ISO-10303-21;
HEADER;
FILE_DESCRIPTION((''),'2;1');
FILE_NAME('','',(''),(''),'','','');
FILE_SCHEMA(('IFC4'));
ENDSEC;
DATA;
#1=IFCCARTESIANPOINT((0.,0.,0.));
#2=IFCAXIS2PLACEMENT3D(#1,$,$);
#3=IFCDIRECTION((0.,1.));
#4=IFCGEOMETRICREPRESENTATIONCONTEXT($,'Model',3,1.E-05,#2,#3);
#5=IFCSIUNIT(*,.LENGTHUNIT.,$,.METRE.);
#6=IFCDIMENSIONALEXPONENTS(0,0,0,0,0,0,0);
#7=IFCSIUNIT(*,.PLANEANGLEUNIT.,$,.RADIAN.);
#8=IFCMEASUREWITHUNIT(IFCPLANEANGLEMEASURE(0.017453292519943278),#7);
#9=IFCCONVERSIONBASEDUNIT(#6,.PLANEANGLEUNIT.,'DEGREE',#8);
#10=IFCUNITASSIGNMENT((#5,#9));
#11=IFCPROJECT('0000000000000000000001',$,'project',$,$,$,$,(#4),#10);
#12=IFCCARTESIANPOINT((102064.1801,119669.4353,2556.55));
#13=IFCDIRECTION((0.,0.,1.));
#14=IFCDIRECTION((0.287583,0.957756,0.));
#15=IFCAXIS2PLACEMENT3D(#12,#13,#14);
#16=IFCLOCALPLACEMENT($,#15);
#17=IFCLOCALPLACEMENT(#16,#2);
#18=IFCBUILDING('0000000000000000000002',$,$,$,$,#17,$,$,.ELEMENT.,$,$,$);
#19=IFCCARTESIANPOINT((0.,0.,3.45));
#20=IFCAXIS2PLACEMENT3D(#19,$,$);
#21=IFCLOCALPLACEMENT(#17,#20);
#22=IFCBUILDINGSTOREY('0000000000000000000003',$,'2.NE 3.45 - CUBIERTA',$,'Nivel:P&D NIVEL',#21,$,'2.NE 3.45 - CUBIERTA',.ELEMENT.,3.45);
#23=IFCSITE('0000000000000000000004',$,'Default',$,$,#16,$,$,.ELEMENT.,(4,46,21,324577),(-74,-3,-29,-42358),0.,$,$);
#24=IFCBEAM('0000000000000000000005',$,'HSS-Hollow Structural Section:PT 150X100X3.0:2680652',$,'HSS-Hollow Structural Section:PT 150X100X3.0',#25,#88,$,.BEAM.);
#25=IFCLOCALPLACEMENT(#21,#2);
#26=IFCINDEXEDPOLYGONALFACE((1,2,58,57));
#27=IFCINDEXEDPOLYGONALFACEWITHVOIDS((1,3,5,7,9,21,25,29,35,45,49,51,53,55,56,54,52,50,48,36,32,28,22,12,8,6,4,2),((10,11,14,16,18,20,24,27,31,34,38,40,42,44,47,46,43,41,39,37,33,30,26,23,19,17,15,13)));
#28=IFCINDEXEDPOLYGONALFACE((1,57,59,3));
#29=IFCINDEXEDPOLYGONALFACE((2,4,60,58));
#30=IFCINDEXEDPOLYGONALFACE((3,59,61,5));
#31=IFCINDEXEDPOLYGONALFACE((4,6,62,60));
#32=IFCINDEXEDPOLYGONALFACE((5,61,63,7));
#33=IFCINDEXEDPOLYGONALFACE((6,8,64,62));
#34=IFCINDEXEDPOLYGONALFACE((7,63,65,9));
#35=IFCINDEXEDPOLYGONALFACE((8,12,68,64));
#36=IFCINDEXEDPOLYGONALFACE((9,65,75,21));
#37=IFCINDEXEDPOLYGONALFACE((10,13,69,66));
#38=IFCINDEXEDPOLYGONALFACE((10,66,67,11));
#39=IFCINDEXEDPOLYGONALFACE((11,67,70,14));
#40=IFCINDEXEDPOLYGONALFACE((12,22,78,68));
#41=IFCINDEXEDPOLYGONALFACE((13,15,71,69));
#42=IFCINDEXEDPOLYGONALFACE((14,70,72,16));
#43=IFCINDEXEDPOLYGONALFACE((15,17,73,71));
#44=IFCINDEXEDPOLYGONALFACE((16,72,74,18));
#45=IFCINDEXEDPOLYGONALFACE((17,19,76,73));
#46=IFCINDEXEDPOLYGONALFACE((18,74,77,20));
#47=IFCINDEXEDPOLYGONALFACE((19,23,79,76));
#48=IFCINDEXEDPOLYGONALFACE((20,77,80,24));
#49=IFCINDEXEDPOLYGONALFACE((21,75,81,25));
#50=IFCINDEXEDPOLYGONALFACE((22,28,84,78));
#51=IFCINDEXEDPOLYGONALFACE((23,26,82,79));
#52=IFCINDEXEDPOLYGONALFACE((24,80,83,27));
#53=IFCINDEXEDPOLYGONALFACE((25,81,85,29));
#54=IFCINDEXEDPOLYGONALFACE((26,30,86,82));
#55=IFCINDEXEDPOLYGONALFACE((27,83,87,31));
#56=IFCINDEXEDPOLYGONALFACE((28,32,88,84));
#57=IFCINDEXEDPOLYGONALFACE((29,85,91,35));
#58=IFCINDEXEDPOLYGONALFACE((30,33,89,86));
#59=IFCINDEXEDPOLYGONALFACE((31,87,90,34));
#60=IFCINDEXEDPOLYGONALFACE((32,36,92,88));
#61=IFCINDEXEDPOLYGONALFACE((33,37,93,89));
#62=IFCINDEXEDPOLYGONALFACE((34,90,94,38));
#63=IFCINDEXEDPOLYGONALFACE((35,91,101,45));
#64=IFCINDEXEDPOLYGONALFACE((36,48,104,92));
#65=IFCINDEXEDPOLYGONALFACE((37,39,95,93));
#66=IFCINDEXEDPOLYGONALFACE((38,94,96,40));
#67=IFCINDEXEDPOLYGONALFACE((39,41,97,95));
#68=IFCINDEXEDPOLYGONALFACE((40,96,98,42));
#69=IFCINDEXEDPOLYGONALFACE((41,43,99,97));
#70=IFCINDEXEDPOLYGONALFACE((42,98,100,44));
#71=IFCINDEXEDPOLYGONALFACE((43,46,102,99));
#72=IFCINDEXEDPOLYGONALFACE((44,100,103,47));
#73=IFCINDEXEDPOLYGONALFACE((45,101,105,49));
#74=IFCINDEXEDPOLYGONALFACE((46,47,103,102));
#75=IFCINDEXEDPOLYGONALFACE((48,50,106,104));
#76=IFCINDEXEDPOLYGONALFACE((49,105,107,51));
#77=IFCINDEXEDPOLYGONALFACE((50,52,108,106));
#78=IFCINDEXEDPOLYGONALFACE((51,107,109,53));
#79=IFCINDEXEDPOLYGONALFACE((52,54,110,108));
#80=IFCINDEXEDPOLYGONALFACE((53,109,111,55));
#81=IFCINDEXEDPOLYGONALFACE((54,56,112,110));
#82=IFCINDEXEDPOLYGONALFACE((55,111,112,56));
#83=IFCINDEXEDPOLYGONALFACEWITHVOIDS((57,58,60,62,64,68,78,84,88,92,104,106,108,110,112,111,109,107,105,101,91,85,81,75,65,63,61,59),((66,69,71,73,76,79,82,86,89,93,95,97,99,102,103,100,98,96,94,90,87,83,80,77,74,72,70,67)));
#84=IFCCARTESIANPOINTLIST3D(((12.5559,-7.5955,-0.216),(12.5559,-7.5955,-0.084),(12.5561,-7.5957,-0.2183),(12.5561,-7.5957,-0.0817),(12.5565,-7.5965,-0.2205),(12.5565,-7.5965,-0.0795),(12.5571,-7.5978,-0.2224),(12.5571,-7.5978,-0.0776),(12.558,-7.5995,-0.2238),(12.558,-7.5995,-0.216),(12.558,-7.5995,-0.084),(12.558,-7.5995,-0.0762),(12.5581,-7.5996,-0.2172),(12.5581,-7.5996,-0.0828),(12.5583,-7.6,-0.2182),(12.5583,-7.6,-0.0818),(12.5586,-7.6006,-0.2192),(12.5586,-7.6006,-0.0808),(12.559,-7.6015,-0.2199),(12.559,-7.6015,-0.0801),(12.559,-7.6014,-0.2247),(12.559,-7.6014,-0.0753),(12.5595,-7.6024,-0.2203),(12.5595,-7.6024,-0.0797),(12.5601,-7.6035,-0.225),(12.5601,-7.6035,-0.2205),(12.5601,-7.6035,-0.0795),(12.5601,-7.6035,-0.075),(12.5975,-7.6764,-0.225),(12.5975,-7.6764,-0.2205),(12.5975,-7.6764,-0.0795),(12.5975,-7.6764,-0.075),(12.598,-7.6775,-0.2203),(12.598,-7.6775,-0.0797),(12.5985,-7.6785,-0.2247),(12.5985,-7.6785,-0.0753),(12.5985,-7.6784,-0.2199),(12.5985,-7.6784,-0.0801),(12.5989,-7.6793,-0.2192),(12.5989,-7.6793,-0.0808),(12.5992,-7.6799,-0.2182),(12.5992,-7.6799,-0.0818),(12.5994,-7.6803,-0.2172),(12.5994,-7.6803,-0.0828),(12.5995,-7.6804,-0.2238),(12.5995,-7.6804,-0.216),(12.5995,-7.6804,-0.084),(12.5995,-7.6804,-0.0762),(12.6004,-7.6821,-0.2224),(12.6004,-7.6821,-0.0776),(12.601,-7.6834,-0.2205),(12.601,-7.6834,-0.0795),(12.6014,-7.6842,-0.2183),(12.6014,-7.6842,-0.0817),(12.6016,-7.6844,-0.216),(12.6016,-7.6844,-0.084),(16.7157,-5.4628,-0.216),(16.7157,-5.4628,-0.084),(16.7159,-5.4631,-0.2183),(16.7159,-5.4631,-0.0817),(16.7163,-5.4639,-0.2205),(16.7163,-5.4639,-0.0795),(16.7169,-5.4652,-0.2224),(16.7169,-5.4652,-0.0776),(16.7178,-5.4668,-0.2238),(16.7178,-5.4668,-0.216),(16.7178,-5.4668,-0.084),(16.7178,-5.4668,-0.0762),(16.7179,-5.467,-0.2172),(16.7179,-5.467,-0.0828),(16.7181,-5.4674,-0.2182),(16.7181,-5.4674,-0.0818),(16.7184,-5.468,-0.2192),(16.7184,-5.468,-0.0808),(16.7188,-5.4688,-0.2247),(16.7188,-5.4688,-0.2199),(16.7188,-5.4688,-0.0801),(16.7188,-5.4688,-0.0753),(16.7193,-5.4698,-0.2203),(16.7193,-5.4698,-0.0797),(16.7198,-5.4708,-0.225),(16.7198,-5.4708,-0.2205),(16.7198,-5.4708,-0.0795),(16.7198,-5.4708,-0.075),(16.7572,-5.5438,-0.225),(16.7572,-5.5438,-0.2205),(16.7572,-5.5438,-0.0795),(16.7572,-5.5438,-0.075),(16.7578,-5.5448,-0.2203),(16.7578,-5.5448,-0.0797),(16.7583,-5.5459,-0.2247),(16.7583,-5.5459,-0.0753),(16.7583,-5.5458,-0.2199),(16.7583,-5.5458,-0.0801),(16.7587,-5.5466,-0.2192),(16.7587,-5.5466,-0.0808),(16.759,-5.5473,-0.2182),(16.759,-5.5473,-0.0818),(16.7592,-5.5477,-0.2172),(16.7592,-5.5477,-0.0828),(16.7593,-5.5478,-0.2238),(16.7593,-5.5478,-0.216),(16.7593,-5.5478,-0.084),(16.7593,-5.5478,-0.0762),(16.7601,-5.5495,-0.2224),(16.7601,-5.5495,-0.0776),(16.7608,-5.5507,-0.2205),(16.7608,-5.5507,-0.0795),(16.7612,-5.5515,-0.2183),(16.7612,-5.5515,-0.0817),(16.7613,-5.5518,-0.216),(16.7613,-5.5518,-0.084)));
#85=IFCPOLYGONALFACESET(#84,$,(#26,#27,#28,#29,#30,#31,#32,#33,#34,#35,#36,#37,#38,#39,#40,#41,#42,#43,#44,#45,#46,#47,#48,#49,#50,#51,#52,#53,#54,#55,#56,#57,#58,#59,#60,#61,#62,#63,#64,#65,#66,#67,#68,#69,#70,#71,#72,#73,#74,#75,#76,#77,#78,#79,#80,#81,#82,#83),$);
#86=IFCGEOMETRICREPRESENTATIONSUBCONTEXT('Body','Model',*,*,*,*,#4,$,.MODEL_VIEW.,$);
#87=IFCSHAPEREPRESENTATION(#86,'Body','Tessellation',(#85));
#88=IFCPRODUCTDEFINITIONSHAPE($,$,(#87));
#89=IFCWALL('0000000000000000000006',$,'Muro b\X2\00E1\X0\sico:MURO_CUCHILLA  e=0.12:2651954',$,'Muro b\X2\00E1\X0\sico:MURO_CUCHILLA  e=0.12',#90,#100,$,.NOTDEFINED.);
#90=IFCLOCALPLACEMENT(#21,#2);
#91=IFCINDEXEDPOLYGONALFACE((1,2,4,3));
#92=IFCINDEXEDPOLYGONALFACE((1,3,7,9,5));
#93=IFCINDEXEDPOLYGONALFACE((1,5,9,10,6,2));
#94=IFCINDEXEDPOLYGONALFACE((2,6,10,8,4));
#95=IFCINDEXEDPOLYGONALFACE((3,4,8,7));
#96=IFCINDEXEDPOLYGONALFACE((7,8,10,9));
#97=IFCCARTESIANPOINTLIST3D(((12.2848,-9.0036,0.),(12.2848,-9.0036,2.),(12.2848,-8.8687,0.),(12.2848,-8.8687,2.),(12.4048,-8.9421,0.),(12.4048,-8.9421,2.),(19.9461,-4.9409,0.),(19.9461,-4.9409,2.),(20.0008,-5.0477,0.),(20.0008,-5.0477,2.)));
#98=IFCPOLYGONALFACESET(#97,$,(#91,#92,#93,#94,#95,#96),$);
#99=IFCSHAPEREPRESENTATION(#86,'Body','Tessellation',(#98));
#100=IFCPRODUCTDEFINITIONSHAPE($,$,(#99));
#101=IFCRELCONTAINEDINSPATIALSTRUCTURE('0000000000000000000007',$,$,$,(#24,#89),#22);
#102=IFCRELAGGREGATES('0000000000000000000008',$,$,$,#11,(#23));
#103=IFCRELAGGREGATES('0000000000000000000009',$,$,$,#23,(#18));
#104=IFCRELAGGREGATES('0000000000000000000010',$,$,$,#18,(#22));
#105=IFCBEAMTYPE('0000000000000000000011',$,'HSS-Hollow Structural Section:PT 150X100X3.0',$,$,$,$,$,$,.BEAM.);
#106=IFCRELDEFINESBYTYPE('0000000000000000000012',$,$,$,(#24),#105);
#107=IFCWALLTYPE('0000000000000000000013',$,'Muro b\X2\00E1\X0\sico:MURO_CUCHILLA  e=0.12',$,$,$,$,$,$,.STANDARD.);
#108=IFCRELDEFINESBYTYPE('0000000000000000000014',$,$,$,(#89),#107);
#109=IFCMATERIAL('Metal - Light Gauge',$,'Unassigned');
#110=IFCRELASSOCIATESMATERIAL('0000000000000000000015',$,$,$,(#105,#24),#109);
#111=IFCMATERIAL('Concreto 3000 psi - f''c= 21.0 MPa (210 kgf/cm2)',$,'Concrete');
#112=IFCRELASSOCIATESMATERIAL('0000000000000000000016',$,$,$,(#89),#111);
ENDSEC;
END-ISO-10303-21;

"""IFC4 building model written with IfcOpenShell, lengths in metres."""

from ifc_helpers import new_model, entity, si_unit, converted_unit, direction, frame, origin, place, context, subcontext, project, spatial, line, arc, indexed_curve, outline, extrude, source, transform, mapped, material, type_object, type_shapes, element, save


model = new_model("IFC4")

# Units and contexts
model_context = context("Model", 3, precision=1e-05, world=origin(), true_north=direction((0.0, 1.0)))
body_context = subcontext(model_context, "Body", "Model", "MODEL_VIEW")
ifc_project = project(units=[si_unit("LENGTHUNIT", "METRE"), converted_unit("PLANEANGLEUNIT", "DEGREE", entity("IfcPlaneAngleMeasure", 0.017453292519943278), si_unit("PLANEANGLEUNIT", "RADIAN"), dimensions=[0, 0, 0, 0, 0, 0, 0])], contexts=[model_context])

# Site, building, storey
site_placement = place(None, frame((102064.1801, 119669.4353, 2556.55), z_axis=(0.0, 0.0, 1.0), x_axis=(0.287583, 0.957756, 0.0)))
site = spatial("IfcSite", under=ifc_project, at=site_placement, Name="Default", CompositionType="ELEMENT", RefLatitude=(4, 46, 21, 324577), RefLongitude=(-74, -3, -29, -42358), RefElevation=0.0)
building_placement = place(site_placement, origin())
building = spatial("IfcBuilding", under=site, at=building_placement, CompositionType="ELEMENT")
storey_placement = place(building_placement, frame((0.0, 0.0, 3.45)))
storey = spatial("IfcBuildingStorey", under=building, at=storey_placement, Name="2.NE 3.45 - CUBIERTA", ObjectType="Nivel:P&D NIVEL", LongName="2.NE 3.45 - CUBIERTA", CompositionType="ELEMENT", Elevation=3.45)

# Beam
ifc_material_1 = material(Name="Metal - Light Gauge", Category="Unassigned")
beam_type_1 = type_object("IfcBeamType", Name="HSS-Hollow Structural Section:PT 150X100X3.0", PredefinedType="BEAM", material=ifc_material_1)
shared_shape_1 = source(origin(), body_context, "Body", "SweptSolid", [
    extrude(outline(indexed_curve([(-0.05, -0.066), (-0.0474, -0.0724), (-0.041, -0.075), (0.041, -0.075), (0.0474, -0.0724), (0.05, -0.066), (0.05, 0.066), (0.0474, 0.0724), (0.041, 0.075), (-0.041, 0.075), (-0.0474, 0.0724), (-0.05, 0.066)], segments=[arc(1, 2, 3), line(3, 4), arc(4, 5, 6), line(6, 7), arc(7, 8, 9), line(9, 10), arc(10, 11, 12), line(12, 1)], self_intersect=False), holes=[indexed_curve([(0.041, -0.0705), (-0.041, -0.0705), (-0.0442, -0.0692), (-0.0455, -0.066), (-0.0455, 0.066), (-0.0442, 0.0692), (-0.041, 0.0705), (0.041, 0.0705), (0.0442, 0.0692), (0.0455, 0.066), (0.0455, -0.066), (0.0442, -0.0692)], segments=[line(1, 2), arc(2, 3, 4), line(4, 5), arc(5, 6, 7), line(7, 8), arc(8, 9, 10), line(10, 11), arc(11, 12, 1)], self_intersect=False)]), frame((-2.3373, 0.0, 0.0), z_axis=(1.0, 0.0, 0.0), x_axis=(0.0, -1.0, 0.0)), (0.0, 0.0, 1.0), 4.6746),
])
type_shapes(beam_type_1, [shared_shape_1])
for number, where, z_axis, x_axis, name in (
    (1, (14.6586, -6.5736, -0.15), (0.0, 0.0, 1.0), (0.889869, 0.456217, 0.0), "HSS-Hollow Structural Section:PT 150X100X3.0:2680652"),
):
    element("IfcBeam", number, at=place(storey_placement, frame(where, z_axis=z_axis, x_axis=x_axis)), inside=storey, type_object=beam_type_1, material=ifc_material_1, Name=name, ObjectType="HSS-Hollow Structural Section:PT 150X100X3.0", PredefinedType="BEAM", context=body_context, shape_type="MappedRepresentation", body=[
        mapped(shared_shape_1, transform((0.0, 0.0, 0.0), scale=1.0)),
    ])

# Wall
ifc_material_2 = material(Name="Concreto 3000 psi - f'c= 21.0 MPa (210 kgf/cm2)", Category="Concrete")
wall_type = type_object("IfcWallType", Name="Muro básico:MURO_CUCHILLA  e=0.12", PredefinedType="STANDARD")
wall_placement = place(storey_placement, frame((19.9735, -4.9943, 0.0), z_axis=(0.0, 0.0, 1.0), x_axis=(-0.889869, -0.456217, 0.0)))
element("IfcWall", 2, at=wall_placement, inside=storey, type_object=wall_type, material=ifc_material_2, Name="Muro básico:MURO_CUCHILLA  e=0.12:2651954", ObjectType="Muro básico:MURO_CUCHILLA  e=0.12", PredefinedType="NOTDEFINED", context=body_context, shape_type="SweptSolid", body=[
    extrude(outline(indexed_curve([(8.6095, -0.06), (8.671, 0.06), (8.5362, 0.06), (0.0, 0.06), (0.0, -0.06), (8.6095, -0.06)], self_intersect=False)), origin(), (0.0, 0.0, 1.0), 2.0),
])

save(model, "model.ifc")
